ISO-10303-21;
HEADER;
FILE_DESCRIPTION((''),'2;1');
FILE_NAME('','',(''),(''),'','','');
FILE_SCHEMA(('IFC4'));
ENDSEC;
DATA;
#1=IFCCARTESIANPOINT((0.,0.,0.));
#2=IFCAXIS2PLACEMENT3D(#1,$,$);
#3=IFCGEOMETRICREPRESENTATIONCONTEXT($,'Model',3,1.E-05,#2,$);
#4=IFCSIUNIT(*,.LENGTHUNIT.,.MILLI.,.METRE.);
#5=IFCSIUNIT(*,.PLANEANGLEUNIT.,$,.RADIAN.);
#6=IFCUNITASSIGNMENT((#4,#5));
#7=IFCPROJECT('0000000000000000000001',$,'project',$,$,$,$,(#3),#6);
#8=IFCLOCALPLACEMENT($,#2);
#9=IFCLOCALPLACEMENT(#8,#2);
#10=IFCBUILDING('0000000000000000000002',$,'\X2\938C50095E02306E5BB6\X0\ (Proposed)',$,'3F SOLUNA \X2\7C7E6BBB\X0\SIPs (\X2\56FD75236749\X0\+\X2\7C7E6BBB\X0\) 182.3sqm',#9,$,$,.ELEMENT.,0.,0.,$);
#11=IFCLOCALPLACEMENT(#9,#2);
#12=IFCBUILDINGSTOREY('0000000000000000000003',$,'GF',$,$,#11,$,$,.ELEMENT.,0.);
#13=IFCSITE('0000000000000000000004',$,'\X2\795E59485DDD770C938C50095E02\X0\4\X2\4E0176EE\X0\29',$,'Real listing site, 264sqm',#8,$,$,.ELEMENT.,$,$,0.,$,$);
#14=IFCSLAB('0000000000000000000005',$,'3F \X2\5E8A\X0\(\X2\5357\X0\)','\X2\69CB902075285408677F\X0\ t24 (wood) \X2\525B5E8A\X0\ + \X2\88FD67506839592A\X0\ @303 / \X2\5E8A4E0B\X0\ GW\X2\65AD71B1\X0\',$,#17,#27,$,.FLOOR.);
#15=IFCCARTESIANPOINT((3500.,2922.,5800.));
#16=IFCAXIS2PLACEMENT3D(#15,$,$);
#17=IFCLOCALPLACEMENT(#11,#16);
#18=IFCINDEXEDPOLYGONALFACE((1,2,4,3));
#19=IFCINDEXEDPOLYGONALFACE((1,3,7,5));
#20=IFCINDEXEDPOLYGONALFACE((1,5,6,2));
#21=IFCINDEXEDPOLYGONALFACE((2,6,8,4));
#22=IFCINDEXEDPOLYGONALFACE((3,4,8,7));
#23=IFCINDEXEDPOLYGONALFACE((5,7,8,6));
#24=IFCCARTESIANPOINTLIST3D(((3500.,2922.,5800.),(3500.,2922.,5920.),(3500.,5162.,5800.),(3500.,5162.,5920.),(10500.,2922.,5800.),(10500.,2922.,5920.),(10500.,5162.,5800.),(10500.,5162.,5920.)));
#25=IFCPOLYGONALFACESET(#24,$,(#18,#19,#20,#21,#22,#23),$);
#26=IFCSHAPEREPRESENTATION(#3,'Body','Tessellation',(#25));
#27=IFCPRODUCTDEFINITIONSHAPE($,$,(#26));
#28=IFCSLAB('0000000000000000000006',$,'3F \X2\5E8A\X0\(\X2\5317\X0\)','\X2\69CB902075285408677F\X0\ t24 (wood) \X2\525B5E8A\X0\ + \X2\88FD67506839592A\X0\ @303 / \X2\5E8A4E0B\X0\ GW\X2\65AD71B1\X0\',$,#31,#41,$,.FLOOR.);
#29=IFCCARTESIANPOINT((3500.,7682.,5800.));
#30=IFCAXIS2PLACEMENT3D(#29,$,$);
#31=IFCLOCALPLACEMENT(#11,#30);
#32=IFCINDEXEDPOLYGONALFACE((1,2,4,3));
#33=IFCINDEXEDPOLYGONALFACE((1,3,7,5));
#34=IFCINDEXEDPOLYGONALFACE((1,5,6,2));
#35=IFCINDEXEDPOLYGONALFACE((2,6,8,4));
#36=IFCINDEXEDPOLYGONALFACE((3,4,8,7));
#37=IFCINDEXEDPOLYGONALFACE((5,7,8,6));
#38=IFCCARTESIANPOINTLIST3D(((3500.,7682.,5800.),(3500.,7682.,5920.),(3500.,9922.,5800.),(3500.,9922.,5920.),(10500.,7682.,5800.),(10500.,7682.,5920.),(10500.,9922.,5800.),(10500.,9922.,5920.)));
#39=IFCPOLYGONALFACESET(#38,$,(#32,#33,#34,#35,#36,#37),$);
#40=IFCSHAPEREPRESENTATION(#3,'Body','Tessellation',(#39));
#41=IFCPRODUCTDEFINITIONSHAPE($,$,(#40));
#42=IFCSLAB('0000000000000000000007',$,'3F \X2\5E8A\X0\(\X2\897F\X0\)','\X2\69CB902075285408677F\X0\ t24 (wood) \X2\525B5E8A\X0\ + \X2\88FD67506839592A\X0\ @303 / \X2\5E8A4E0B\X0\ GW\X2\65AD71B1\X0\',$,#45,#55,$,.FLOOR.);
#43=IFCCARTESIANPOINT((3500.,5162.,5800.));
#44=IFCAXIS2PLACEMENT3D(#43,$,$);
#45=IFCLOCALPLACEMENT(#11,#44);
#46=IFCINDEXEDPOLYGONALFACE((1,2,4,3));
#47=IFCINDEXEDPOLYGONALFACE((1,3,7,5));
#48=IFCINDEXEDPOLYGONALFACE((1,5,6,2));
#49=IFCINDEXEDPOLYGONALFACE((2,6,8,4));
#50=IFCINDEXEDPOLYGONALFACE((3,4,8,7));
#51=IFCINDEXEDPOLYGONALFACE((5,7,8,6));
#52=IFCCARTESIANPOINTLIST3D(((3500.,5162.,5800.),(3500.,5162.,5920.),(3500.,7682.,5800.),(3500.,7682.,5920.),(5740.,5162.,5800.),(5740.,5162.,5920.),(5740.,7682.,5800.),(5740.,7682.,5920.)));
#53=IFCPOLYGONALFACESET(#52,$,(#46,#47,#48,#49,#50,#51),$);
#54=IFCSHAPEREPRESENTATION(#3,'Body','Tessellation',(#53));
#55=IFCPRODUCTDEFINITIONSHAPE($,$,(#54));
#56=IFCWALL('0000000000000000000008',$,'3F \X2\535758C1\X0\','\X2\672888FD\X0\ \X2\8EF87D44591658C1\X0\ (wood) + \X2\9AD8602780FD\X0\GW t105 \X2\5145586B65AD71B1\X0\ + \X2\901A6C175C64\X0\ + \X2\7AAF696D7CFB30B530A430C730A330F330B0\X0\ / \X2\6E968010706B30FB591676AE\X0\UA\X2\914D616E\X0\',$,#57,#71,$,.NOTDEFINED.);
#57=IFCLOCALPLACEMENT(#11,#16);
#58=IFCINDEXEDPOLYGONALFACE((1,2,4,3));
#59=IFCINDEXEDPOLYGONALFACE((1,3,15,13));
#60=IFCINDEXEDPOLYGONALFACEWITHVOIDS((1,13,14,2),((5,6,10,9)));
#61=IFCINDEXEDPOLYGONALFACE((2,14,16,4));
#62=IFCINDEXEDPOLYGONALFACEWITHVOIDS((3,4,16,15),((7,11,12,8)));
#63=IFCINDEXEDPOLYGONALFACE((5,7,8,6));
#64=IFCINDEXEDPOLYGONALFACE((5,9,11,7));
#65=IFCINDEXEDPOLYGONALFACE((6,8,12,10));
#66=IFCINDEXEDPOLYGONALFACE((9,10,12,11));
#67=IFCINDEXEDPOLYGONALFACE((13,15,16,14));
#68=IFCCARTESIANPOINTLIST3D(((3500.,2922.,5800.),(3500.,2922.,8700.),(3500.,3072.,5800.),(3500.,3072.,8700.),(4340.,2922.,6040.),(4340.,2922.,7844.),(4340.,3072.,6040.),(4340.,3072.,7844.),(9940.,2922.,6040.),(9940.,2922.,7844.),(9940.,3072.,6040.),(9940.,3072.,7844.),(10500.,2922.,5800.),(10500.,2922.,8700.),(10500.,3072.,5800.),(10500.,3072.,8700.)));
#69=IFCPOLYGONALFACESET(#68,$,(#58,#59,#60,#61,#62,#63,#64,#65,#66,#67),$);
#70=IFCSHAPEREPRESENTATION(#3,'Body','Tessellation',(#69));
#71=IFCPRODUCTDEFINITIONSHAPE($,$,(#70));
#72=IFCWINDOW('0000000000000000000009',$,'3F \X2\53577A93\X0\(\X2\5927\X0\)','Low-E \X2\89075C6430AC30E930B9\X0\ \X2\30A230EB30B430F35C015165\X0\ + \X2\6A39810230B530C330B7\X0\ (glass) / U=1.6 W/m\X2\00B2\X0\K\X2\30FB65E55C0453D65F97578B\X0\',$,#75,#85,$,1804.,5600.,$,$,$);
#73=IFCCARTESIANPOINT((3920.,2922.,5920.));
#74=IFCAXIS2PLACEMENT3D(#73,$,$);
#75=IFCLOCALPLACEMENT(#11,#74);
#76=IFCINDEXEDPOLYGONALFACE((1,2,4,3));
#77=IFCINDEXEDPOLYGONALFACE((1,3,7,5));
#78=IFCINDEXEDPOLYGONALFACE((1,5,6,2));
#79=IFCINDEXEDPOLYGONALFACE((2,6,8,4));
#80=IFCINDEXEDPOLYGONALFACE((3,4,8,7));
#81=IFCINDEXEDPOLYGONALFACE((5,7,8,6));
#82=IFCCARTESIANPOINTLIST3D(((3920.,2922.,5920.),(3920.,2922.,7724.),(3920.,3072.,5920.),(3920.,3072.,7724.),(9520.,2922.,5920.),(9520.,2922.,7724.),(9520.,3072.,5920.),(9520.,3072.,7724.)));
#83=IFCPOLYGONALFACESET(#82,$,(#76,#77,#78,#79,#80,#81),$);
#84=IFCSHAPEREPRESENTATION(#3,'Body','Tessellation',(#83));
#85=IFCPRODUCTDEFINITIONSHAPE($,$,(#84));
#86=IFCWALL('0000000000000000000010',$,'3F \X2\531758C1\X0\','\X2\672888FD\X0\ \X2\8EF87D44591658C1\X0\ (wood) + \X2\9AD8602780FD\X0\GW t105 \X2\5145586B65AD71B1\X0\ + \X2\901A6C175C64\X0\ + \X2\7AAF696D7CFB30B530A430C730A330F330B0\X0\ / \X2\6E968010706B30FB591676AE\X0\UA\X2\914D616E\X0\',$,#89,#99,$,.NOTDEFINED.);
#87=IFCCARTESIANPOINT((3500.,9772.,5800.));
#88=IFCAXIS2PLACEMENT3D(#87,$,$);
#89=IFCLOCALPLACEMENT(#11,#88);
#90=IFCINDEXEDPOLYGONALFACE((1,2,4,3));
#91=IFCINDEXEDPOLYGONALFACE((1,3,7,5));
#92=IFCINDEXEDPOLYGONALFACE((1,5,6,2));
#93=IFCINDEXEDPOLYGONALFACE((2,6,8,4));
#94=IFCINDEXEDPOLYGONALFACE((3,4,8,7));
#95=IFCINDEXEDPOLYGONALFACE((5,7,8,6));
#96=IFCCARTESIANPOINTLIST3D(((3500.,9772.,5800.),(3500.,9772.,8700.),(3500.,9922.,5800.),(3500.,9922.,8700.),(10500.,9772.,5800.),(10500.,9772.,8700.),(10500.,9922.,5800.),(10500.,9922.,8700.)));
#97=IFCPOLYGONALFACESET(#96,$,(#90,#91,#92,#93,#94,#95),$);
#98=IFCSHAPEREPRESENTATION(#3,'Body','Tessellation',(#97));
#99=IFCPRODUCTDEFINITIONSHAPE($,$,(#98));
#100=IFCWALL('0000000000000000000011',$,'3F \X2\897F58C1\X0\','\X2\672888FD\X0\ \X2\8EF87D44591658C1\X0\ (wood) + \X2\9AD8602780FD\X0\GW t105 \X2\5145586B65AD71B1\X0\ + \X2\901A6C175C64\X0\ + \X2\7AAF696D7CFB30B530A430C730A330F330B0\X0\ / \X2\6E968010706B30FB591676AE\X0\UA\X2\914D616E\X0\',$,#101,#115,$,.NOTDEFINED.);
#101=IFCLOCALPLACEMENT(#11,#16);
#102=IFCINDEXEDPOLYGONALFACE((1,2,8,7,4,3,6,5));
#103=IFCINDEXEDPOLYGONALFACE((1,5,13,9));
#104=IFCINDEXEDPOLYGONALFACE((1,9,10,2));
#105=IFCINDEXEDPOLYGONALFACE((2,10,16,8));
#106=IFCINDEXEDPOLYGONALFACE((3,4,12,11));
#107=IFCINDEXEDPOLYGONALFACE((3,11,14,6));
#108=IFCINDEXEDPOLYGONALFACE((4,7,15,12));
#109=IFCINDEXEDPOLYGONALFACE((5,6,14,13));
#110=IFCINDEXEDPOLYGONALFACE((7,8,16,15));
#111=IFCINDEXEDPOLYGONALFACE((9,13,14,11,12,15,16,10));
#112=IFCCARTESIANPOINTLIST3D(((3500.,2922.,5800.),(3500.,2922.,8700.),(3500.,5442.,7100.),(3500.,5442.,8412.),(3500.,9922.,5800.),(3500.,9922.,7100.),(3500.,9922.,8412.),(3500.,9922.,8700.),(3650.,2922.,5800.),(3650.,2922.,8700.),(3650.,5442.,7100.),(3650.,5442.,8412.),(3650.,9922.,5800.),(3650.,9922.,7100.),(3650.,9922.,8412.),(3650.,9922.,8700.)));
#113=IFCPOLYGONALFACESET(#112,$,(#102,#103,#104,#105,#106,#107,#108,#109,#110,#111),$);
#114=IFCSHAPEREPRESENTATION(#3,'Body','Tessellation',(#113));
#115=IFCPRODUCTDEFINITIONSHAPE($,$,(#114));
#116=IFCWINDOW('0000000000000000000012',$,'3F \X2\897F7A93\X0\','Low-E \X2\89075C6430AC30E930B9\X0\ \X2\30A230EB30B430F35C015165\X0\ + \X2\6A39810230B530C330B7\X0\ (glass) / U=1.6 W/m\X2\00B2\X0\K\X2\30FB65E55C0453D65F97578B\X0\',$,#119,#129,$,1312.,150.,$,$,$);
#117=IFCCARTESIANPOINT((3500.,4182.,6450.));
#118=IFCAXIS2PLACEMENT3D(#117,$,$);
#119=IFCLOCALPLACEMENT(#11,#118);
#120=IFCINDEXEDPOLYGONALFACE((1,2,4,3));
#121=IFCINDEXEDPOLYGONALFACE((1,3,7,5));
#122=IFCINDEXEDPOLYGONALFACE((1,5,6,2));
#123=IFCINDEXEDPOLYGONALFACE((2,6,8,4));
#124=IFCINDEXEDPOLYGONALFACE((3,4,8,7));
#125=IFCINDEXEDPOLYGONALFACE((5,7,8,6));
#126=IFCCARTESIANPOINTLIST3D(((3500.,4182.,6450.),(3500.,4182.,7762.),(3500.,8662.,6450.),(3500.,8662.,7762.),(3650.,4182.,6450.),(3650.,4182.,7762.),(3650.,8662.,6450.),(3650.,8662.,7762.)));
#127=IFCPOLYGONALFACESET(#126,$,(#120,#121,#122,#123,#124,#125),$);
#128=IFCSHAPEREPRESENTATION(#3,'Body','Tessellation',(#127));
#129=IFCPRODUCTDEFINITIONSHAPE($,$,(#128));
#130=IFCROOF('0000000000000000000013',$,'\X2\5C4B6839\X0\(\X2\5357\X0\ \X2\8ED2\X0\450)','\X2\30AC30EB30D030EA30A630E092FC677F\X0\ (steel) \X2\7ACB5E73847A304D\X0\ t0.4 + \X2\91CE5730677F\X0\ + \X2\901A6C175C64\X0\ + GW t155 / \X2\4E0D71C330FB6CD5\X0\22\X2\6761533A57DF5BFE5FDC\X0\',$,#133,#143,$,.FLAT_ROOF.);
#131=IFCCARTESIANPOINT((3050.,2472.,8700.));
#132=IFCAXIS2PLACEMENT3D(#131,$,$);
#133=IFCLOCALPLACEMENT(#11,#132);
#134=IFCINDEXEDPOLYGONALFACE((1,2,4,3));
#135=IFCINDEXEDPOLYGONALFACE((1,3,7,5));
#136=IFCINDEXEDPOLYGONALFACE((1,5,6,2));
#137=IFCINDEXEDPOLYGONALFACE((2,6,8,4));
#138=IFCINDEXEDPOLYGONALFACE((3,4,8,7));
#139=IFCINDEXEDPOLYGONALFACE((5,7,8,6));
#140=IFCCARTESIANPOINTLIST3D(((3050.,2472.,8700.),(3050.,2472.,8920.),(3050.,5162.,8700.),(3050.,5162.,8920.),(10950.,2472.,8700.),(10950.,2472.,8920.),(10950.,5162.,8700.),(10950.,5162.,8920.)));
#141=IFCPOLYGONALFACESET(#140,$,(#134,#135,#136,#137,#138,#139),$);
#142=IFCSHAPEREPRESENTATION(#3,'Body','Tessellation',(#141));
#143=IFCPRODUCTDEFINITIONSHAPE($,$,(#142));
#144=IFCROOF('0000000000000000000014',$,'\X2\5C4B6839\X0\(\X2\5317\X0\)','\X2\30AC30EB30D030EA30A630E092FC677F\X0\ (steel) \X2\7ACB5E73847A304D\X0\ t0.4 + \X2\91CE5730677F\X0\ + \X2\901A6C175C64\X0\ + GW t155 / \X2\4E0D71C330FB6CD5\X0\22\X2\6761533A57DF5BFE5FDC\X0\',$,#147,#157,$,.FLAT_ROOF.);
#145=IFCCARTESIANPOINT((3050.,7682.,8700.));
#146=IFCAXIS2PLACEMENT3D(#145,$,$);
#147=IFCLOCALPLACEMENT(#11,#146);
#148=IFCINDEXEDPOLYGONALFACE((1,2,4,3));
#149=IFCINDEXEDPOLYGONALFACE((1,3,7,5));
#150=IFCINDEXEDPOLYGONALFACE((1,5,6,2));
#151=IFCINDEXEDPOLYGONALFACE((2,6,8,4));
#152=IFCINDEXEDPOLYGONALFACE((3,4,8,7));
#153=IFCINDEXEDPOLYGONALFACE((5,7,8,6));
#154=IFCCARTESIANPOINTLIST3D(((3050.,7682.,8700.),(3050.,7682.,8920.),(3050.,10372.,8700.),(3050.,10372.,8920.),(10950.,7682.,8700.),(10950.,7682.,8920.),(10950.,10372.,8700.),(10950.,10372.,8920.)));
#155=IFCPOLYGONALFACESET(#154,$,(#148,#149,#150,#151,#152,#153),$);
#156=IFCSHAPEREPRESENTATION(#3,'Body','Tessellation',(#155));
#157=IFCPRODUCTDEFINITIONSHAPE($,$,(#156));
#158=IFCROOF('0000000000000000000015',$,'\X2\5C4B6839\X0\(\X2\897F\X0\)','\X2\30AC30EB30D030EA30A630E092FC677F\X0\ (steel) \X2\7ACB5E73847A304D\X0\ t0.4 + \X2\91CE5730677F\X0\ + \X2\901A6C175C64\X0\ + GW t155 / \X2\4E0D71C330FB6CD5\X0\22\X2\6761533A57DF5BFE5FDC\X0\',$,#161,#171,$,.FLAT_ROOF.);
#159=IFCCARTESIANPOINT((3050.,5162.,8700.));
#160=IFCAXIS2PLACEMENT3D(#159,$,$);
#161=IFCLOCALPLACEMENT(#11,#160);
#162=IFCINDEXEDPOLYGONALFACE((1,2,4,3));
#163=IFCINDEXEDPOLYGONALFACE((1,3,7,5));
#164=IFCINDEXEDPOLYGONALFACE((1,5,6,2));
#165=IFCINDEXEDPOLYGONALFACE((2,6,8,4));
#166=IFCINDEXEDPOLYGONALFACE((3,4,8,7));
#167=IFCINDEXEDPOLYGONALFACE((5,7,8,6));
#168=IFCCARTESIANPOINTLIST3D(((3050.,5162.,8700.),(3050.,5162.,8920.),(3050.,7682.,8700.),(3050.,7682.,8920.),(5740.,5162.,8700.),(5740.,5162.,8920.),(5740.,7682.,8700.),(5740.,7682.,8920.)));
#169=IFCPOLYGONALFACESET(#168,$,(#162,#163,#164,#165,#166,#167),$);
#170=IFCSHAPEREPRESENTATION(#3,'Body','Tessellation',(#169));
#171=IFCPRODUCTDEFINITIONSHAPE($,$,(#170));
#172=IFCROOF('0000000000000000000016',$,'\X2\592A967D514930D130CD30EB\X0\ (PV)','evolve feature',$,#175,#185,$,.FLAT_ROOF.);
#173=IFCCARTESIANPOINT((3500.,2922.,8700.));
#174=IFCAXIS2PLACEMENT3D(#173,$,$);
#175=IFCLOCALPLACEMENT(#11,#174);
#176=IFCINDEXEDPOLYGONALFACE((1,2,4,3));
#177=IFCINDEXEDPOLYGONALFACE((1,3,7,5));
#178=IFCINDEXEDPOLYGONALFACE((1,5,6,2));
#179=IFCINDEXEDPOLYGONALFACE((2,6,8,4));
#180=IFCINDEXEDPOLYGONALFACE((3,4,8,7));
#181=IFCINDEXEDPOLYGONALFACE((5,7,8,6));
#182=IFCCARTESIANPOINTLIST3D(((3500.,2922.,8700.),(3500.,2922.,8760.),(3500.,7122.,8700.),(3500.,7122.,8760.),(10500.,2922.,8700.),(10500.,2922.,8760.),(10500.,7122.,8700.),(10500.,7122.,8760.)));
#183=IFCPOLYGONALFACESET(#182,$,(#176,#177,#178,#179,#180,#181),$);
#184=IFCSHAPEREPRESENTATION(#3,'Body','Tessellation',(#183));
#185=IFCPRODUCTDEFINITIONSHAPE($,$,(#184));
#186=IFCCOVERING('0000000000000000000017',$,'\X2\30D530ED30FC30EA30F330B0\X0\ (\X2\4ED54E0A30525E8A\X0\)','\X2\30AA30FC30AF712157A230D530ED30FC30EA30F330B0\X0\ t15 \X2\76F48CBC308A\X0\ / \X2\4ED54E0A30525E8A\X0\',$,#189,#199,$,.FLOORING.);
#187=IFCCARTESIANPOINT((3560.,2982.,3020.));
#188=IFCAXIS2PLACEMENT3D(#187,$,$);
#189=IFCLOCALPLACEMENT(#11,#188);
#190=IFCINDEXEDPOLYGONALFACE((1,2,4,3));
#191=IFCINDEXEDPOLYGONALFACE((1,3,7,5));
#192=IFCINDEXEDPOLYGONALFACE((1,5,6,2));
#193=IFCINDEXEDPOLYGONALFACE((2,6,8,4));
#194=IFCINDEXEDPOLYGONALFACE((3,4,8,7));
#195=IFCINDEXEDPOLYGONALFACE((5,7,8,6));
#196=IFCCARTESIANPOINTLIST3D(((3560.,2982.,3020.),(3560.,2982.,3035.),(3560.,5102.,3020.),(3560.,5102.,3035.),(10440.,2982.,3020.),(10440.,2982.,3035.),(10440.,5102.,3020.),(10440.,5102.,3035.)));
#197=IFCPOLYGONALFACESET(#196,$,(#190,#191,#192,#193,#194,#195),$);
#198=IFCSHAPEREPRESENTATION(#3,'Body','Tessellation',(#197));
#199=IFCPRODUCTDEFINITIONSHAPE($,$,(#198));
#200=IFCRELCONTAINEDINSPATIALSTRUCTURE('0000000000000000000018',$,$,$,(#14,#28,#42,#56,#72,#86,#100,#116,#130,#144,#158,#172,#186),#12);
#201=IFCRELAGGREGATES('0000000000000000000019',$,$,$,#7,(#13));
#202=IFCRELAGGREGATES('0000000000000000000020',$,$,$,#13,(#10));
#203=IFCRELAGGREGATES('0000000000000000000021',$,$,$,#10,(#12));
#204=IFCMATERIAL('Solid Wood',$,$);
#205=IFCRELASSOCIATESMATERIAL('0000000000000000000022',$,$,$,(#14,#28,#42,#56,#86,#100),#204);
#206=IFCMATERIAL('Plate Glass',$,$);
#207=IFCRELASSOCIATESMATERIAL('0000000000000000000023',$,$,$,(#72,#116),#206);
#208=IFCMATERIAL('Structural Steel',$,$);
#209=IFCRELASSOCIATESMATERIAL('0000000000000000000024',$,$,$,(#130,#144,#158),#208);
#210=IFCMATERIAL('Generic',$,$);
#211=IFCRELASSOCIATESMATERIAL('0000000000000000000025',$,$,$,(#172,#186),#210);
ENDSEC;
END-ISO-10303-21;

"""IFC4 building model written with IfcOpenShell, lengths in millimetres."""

from ifc_helpers import new_model, si_unit, frame, frame_2d, origin, place, context, project, spatial, rectangle, extrude, material, element, fill, save


model = new_model("IFC4")

# Units and contexts
model_context = context("Model", 3, precision=1e-05, world=origin())
ifc_project = project(units=[si_unit("LENGTHUNIT", "METRE", prefix="MILLI"), si_unit("PLANEANGLEUNIT", "RADIAN")], contexts=[model_context])

# Site, building, storey
site_placement = place(None, origin())
site = spatial("IfcSite", under=ifc_project, at=site_placement, Name="神奈川県鎌倉市4丁目29", ObjectType="Real listing site, 264sqm", CompositionType="ELEMENT", RefElevation=0.0)
building_placement = place(site_placement, origin())
building = spatial("IfcBuilding", under=site, at=building_placement, Name="鎌倉市の家 (Proposed)", ObjectType="3F SOLUNA 籾殻SIPs (国産杉+籾殻) 182.3sqm", CompositionType="ELEMENT", ElevationOfRefHeight=0.0, ElevationOfTerrain=0.0)
storey_placement = place(building_placement, origin())
storey = spatial("IfcBuildingStorey", under=building, at=storey_placement, Name="GF", CompositionType="ELEMENT", Elevation=0.0)

# Slabs
ifc_material_1 = material(Name="Solid Wood")
slab_1_placement = place(storey_placement, frame((3500.0, 2922.0, 5800.0)))
element("IfcSlab", 1, at=slab_1_placement, inside=storey, material=ifc_material_1, Name="3F 床(南)", Description="構造用合板 t24 (wood) 剛床 + 製材根太 @303 / 床下 GW断熱", PredefinedType="FLOOR", context=model_context, shape_type="SweptSolid", body=[
    extrude(rectangle(XDim=7000.0, YDim=2240.0, at=frame_2d((3500.0, 1120.0))), frame((3500.0, 2922.0, 5800.0)), (0.0, 0.0, 1.0), 120.0),
])
slab_2_placement = place(storey_placement, frame((3500.0, 7682.0, 5800.0)))
element("IfcSlab", 2, at=slab_2_placement, inside=storey, material=ifc_material_1, Name="3F 床(北)", Description="構造用合板 t24 (wood) 剛床 + 製材根太 @303 / 床下 GW断熱", PredefinedType="FLOOR", context=model_context, shape_type="SweptSolid", body=[
    extrude(rectangle(XDim=7000.0, YDim=2240.0, at=frame_2d((3500.0, 1120.0))), frame((3500.0, 7682.0, 5800.0)), (0.0, 0.0, 1.0), 120.0),
])
slab_3_placement = place(storey_placement, frame((3500.0, 5162.0, 5800.0)))
element("IfcSlab", 3, at=slab_3_placement, inside=storey, material=ifc_material_1, Name="3F 床(西)", Description="構造用合板 t24 (wood) 剛床 + 製材根太 @303 / 床下 GW断熱", PredefinedType="FLOOR", context=model_context, shape_type="SweptSolid", body=[
    extrude(rectangle(XDim=2240.0, YDim=2520.0, at=frame_2d((1120.0, 1260.0))), frame((3500.0, 5162.0, 5800.0)), (0.0, 0.0, 1.0), 120.0),
])

# Wall, opening, window
wall_1_placement = place(storey_placement, frame((3500.0, 2922.0, 5800.0)))
wall_1 = element("IfcWall", 4, at=wall_1_placement, inside=storey, material=ifc_material_1, Name="3F 南壁", Description="木製 軸組外壁 (wood) + 高性能GW t105 充填断熱 + 通気層 + 窯業系サイディング / 準耐火・外皮UA配慮", PredefinedType="NOTDEFINED", context=model_context, shape_type="SweptSolid", body=[
    extrude(rectangle(XDim=7000.0, YDim=150.0, at=frame_2d((3500.0, 75.0))), frame((3500.0, 2922.0, 5800.0)), (0.0, 0.0, 1.0), 2900.0),
])
opening_1_placement = place(storey_placement, frame((3920.0, 2922.0, 5920.0)))
opening_1 = element("IfcOpeningElement", 5, at=opening_1_placement, cuts=wall_1, PredefinedType="NOTDEFINED", context=model_context, shape_type="SweptSolid", body=[
    extrude(rectangle(XDim=5600.0, YDim=150.0, at=frame_2d((2800.0, 75.0))), frame((3920.0, 2922.0, 5920.0)), (0.0, 0.0, 1.0), 1804.0),
])
ifc_material_2 = material(Name="Plate Glass")
window_1_placement = place(storey_placement, frame((3920.0, 2922.0, 5920.0)))
window_1 = element("IfcWindow", 6, at=window_1_placement, inside=storey, material=ifc_material_2, Name="3F 南窓(大)", Description="Low-E 複層ガラス アルゴン封入 + 樹脂サッシ (glass) / U=1.6 W/m²K・日射取得型", OverallHeight=1804.0, OverallWidth=5600.0, context=model_context, shape_type="SweptSolid", body=[
    extrude(rectangle(XDim=5600.0, YDim=150.0, at=frame_2d((2800.0, 75.0))), frame((3920.0, 2922.0, 5920.0)), (0.0, 0.0, 1.0), 1804.0),
])
fill(opening_1, window_1)

# Wall
wall_2_placement = place(storey_placement, frame((3500.0, 9772.0, 5800.0)))
element("IfcWall", 7, at=wall_2_placement, inside=storey, material=ifc_material_1, Name="3F 北壁", Description="木製 軸組外壁 (wood) + 高性能GW t105 充填断熱 + 通気層 + 窯業系サイディング / 準耐火・外皮UA配慮", PredefinedType="NOTDEFINED", context=model_context, shape_type="SweptSolid", body=[
    extrude(rectangle(XDim=7000.0, YDim=150.0, at=frame_2d((3500.0, 75.0))), frame((3500.0, 9772.0, 5800.0)), (0.0, 0.0, 1.0), 2900.0),
])

# Wall, opening, window
wall_3_placement = place(storey_placement, frame((3500.0, 2922.0, 5800.0)))
wall_3 = element("IfcWall", 8, at=wall_3_placement, inside=storey, material=ifc_material_1, Name="3F 西壁", Description="木製 軸組外壁 (wood) + 高性能GW t105 充填断熱 + 通気層 + 窯業系サイディング / 準耐火・外皮UA配慮", PredefinedType="NOTDEFINED", context=model_context, shape_type="SweptSolid", body=[
    extrude(rectangle(XDim=150.0, YDim=7000.0, at=frame_2d((75.0, 3500.0))), frame((3500.0, 2922.0, 5800.0)), (0.0, 0.0, 1.0), 2900.0),
])
opening_2_placement = place(storey_placement, frame((3500.0, 4182.0, 6450.0)))
opening_2 = element("IfcOpeningElement", 9, at=opening_2_placement, cuts=wall_3, PredefinedType="NOTDEFINED", context=model_context, shape_type="SweptSolid", body=[
    extrude(rectangle(XDim=150.0, YDim=4480.0, at=frame_2d((75.0, 2240.0))), frame((3500.0, 4182.0, 6450.0)), (0.0, 0.0, 1.0), 1312.0),
])
window_2_placement = place(storey_placement, frame((3500.0, 4182.0, 6450.0)))
window_2 = element("IfcWindow", 10, at=window_2_placement, inside=storey, material=ifc_material_2, Name="3F 西窓", Description="Low-E 複層ガラス アルゴン封入 + 樹脂サッシ (glass) / U=1.6 W/m²K・日射取得型", OverallHeight=1312.0, OverallWidth=150.0, context=model_context, shape_type="SweptSolid", body=[
    extrude(rectangle(XDim=150.0, YDim=4480.0, at=frame_2d((75.0, 2240.0))), frame((3500.0, 4182.0, 6450.0)), (0.0, 0.0, 1.0), 1312.0),
])
fill(opening_2, window_2)

# Roofs
ifc_material_3 = material(Name="Structural Steel")
roof_1_placement = place(storey_placement, frame((3050.0, 2472.0, 8700.0)))
element("IfcRoof", 11, at=roof_1_placement, inside=storey, material=ifc_material_3, Name="屋根(南 軒450)", Description="ガルバリウム鋼板 (steel) 立平葺き t0.4 + 野地板 + 通気層 + GW t155 / 不燃・法22条区域対応", PredefinedType="FLAT_ROOF", context=model_context, shape_type="SweptSolid", body=[
    extrude(rectangle(XDim=7900.0, YDim=2690.0, at=frame_2d((3950.0, 1345.0))), frame((3050.0, 2472.0, 8700.0)), (0.0, 0.0, 1.0), 220.0),
])
roof_2_placement = place(storey_placement, frame((3050.0, 7682.0, 8700.0)))
element("IfcRoof", 12, at=roof_2_placement, inside=storey, material=ifc_material_3, Name="屋根(北)", Description="ガルバリウム鋼板 (steel) 立平葺き t0.4 + 野地板 + 通気層 + GW t155 / 不燃・法22条区域対応", PredefinedType="FLAT_ROOF", context=model_context, shape_type="SweptSolid", body=[
    extrude(rectangle(XDim=7900.0, YDim=2690.0, at=frame_2d((3950.0, 1345.0))), frame((3050.0, 7682.0, 8700.0)), (0.0, 0.0, 1.0), 220.0),
])
roof_3_placement = place(storey_placement, frame((3050.0, 5162.0, 8700.0)))
element("IfcRoof", 13, at=roof_3_placement, inside=storey, material=ifc_material_3, Name="屋根(西)", Description="ガルバリウム鋼板 (steel) 立平葺き t0.4 + 野地板 + 通気層 + GW t155 / 不燃・法22条区域対応", PredefinedType="FLAT_ROOF", context=model_context, shape_type="SweptSolid", body=[
    extrude(rectangle(XDim=2690.0, YDim=2520.0, at=frame_2d((1345.0, 1260.0))), frame((3050.0, 5162.0, 8700.0)), (0.0, 0.0, 1.0), 220.0),
])
ifc_material_4 = material(Name="Generic")
roof_4_placement = place(storey_placement, frame((3500.0, 2922.0, 8700.0)))
element("IfcRoof", 14, at=roof_4_placement, inside=storey, material=ifc_material_4, Name="太陽光パネル (PV)", Description="evolve feature", PredefinedType="FLAT_ROOF", context=model_context, shape_type="SweptSolid", body=[
    extrude(rectangle(XDim=7000.0, YDim=4200.0, at=frame_2d((3500.0, 2100.0))), frame((3500.0, 2922.0, 8700.0)), (0.0, 0.0, 1.0), 60.0),
])

# Covering
covering_1_placement = place(storey_placement, frame((3560.0, 2982.0, 3020.0)))
element("IfcCovering", 15, at=covering_1_placement, inside=storey, material=ifc_material_4, Name="フローリング (仕上げ床)", Description="オーク無垢フローリング t15 直貼り / 仕上げ床", PredefinedType="FLOORING", context=model_context, shape_type="SweptSolid", body=[
    extrude(rectangle(XDim=6880.0, YDim=2120.0, at=frame_2d((3440.0, 1060.0))), frame((3560.0, 2982.0, 3020.0)), (0.0, 0.0, 1.0), 15.0),
])

save(model, "model.ifc")
